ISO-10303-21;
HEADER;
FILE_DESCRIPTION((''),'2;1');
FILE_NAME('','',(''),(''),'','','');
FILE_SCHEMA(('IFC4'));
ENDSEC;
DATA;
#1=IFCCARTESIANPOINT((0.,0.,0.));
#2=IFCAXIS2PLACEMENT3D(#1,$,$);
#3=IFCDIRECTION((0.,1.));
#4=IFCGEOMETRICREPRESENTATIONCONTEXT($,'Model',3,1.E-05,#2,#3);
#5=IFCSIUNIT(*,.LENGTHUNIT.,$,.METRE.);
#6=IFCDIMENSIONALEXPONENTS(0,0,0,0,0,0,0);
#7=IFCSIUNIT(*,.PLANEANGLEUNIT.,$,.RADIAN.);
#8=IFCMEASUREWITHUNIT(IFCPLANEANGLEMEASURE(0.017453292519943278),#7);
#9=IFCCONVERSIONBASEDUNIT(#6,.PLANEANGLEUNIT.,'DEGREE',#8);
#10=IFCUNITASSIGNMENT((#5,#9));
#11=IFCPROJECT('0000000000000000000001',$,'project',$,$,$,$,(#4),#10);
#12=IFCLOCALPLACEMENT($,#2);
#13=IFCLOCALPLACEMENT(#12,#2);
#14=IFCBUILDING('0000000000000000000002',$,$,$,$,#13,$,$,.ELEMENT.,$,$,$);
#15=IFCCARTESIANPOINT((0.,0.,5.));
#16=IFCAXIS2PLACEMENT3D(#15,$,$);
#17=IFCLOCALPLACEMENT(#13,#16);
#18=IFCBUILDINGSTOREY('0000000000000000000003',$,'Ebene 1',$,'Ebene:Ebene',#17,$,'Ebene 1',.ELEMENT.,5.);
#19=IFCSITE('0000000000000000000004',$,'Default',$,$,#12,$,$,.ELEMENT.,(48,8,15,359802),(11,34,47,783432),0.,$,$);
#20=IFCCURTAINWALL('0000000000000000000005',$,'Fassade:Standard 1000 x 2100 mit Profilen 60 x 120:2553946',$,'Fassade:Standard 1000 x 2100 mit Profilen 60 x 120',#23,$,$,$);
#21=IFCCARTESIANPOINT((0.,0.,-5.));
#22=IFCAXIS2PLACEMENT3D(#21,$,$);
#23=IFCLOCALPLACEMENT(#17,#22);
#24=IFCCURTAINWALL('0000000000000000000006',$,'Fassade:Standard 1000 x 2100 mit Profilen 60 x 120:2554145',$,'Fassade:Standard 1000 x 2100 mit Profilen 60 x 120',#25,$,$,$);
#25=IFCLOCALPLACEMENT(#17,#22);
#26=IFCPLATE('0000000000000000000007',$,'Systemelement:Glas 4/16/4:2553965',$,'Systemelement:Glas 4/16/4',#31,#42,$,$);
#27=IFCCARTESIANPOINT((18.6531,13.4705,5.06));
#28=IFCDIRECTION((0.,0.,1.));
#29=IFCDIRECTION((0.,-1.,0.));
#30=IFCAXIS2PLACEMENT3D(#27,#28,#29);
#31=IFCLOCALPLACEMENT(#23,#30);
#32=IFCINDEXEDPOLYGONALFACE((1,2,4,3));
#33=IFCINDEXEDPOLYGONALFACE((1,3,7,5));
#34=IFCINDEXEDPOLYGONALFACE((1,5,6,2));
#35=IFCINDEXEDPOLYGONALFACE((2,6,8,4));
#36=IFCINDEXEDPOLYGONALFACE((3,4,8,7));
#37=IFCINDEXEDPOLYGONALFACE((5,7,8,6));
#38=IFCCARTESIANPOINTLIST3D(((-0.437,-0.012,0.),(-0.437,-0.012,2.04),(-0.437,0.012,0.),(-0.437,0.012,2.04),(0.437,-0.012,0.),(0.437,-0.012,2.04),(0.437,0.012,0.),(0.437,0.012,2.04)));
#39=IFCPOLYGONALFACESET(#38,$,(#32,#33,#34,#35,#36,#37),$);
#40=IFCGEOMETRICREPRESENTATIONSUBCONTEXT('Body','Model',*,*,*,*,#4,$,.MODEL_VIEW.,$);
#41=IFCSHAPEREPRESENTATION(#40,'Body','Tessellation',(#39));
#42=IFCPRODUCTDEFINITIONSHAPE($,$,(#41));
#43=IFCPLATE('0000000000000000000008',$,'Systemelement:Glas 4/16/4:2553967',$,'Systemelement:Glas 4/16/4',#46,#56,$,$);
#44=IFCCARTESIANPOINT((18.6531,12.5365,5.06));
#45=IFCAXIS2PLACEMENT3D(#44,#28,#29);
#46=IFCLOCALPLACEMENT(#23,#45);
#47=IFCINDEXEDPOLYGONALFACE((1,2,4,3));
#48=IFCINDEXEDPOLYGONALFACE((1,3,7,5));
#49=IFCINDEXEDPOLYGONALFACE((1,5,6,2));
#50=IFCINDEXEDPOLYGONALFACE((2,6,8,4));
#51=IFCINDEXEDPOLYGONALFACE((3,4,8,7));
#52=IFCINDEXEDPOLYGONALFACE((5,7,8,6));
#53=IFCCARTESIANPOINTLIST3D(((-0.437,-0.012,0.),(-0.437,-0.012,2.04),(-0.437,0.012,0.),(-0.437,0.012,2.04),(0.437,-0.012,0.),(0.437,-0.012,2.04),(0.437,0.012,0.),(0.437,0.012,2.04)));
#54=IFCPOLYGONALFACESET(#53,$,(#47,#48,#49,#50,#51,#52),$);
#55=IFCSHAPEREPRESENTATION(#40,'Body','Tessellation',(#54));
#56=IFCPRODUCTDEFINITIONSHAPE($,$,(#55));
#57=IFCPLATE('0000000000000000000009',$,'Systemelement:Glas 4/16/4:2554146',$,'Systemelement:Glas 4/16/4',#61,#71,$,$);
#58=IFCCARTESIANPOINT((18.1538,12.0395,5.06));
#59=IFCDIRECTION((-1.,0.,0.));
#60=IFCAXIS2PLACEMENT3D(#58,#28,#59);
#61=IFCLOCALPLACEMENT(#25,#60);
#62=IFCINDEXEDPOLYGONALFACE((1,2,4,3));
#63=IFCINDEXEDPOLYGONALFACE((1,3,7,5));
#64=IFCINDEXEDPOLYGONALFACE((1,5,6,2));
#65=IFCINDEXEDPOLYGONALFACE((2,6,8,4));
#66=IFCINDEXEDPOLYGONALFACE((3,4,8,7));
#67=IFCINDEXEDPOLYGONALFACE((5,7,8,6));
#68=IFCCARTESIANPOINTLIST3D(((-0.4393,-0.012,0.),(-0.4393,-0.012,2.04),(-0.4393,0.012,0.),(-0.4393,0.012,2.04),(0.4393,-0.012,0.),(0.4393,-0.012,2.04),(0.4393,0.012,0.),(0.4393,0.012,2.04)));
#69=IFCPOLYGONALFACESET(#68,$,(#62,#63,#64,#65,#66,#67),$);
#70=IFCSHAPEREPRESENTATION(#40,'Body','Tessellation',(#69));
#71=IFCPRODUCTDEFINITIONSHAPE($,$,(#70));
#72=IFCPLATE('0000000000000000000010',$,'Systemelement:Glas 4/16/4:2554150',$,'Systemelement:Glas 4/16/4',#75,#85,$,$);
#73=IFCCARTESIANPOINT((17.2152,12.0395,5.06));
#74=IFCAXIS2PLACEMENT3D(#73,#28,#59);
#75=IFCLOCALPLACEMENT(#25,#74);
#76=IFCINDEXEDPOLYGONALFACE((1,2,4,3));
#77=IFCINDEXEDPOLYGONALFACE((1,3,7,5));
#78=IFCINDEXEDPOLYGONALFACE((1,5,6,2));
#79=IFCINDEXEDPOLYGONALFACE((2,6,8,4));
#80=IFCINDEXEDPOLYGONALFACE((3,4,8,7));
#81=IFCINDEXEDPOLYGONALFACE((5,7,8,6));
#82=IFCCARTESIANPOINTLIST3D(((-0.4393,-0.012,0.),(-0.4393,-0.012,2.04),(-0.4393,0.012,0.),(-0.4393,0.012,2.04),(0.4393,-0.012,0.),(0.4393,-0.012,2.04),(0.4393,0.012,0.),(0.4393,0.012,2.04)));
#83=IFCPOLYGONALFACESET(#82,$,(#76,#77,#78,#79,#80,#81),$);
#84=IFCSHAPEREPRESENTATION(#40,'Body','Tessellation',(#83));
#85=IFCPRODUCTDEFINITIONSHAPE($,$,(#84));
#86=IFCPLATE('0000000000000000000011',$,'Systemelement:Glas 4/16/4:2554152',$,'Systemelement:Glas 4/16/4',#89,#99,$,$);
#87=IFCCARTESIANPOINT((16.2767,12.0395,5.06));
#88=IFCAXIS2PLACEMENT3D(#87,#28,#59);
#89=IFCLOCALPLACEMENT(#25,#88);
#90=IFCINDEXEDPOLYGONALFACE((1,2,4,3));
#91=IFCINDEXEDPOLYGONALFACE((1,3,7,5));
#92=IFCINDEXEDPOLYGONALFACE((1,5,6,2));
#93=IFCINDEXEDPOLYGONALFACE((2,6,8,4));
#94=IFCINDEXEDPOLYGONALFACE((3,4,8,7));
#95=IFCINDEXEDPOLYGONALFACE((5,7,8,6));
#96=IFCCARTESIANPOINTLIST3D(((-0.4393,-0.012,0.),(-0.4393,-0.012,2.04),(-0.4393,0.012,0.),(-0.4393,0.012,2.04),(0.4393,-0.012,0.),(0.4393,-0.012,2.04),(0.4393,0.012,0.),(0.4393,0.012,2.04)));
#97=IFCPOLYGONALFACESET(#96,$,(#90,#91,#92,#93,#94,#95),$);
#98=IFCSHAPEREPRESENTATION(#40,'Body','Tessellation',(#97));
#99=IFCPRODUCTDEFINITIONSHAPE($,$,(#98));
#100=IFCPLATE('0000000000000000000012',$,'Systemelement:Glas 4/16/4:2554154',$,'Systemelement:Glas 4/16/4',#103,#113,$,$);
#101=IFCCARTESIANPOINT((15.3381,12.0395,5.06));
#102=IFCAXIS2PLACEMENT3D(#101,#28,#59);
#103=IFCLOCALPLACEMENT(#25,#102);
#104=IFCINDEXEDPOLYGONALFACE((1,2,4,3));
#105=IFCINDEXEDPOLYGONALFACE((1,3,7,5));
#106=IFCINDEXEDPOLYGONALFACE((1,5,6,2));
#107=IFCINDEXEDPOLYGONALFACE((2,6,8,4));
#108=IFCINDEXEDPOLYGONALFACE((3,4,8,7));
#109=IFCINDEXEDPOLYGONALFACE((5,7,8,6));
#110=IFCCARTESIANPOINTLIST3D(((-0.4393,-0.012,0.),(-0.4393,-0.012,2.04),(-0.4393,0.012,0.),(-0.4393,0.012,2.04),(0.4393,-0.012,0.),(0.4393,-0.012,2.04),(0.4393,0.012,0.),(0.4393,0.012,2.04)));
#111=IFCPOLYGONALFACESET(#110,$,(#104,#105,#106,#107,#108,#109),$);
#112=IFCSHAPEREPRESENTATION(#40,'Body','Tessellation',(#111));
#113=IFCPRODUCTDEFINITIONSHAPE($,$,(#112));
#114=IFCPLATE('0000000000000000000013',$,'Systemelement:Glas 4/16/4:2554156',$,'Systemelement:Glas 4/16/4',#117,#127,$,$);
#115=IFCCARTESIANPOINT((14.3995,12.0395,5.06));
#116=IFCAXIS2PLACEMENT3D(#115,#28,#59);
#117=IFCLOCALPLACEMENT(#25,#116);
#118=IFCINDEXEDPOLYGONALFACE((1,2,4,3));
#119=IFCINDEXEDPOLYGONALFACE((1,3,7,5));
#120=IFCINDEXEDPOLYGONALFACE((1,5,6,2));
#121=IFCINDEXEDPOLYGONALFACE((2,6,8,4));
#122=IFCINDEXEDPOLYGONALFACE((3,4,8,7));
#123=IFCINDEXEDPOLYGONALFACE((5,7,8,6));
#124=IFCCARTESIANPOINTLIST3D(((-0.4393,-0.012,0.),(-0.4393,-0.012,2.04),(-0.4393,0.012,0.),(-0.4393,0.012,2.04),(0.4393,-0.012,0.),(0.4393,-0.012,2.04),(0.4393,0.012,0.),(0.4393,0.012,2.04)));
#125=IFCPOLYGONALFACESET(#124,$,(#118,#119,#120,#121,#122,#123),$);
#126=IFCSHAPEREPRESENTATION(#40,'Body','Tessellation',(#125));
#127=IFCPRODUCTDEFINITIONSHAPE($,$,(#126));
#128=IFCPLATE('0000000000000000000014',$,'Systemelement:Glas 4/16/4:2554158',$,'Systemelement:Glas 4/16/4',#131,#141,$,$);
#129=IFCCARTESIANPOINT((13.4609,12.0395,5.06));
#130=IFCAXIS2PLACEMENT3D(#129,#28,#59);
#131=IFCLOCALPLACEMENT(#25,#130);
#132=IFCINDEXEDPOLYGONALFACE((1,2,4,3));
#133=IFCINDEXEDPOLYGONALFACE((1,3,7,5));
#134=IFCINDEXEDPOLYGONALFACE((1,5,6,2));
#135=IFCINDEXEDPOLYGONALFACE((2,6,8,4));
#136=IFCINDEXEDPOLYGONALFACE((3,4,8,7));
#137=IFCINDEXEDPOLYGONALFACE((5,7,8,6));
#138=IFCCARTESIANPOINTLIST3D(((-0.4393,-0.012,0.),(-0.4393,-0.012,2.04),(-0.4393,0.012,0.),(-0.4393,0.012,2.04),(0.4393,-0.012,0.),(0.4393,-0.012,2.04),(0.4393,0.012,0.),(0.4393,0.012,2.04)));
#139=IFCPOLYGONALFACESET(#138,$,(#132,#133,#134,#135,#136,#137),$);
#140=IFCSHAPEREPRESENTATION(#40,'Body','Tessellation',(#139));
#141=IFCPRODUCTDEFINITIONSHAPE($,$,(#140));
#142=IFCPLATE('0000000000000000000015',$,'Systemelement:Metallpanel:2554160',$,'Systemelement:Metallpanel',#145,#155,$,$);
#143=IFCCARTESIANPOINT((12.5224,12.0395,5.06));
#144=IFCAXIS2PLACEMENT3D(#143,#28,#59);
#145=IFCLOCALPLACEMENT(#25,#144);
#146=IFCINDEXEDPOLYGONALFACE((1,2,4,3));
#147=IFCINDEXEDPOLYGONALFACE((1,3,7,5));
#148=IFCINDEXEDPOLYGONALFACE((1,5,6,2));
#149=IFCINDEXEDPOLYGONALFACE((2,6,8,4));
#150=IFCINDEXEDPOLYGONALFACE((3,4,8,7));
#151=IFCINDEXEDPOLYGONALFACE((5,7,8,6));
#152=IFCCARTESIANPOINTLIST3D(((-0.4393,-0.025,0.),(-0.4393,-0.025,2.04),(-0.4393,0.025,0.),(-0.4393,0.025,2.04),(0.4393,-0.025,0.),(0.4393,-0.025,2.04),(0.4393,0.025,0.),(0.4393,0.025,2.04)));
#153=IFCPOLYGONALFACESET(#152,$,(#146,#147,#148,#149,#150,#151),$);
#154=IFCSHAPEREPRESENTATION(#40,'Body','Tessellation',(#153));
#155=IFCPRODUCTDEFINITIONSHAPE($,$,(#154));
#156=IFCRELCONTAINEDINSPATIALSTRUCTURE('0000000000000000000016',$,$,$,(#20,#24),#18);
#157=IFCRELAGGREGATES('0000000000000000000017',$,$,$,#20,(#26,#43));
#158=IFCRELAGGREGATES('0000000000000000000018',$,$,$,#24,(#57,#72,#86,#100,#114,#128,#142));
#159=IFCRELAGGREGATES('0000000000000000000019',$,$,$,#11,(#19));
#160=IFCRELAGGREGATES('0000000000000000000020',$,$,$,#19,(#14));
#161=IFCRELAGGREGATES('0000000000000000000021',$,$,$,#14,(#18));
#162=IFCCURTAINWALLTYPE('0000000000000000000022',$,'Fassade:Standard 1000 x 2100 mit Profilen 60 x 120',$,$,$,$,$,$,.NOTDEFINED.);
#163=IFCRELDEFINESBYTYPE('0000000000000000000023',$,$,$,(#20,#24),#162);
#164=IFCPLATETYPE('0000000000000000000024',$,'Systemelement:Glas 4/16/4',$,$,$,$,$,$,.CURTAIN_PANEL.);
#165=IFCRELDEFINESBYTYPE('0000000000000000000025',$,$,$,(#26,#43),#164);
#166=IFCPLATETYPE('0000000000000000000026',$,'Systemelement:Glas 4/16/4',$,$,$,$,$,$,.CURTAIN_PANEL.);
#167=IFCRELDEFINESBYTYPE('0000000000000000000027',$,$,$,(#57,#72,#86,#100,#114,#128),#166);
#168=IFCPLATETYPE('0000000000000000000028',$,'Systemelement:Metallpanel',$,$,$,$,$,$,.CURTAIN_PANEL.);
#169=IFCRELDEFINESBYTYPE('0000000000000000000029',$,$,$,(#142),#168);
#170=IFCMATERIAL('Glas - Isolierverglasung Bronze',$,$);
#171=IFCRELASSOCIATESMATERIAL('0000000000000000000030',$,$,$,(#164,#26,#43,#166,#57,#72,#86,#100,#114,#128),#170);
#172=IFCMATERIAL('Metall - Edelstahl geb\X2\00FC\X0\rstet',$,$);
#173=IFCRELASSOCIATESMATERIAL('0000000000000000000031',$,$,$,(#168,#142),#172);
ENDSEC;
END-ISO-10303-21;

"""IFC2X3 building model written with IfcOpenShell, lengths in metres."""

from ifc_helpers import new_model, entity, si_unit, converted_unit, direction, frame, origin, origin_2d_with_axis, place, context, subcontext, project, spatial, rectangle, extrude, source, transform, mapped, material, type_object, type_shapes, element, aggregate, save


model = new_model("IFC2X3")

# Units and contexts
model_context = context("Model", 3, precision=1e-05, world=origin(), true_north=direction((0.0, 1.0)))
body_context = subcontext(model_context, "Body", "Model", "MODEL_VIEW")
ifc_project = project(units=[si_unit("LENGTHUNIT", "METRE"), converted_unit("PLANEANGLEUNIT", "DEGREE", entity("IfcPlaneAngleMeasure", 0.017453292519943278), si_unit("PLANEANGLEUNIT", "RADIAN"), dimensions=[0, 0, 0, 0, 0, 0, 0])], contexts=[model_context])

# Site, building, storey
site_placement = place(None, origin())
site = spatial("IfcSite", under=ifc_project, at=site_placement, Name="Default", CompositionType="ELEMENT", RefLatitude=(48, 8, 15, 359802), RefLongitude=(11, 34, 47, 783432), RefElevation=0.0)
building_placement = place(site_placement, origin())
building = spatial("IfcBuilding", under=site, at=building_placement, CompositionType="ELEMENT")
storey_placement = place(building_placement, frame((0.0, 0.0, 5.0)))
storey = spatial("IfcBuildingStorey", under=building, at=storey_placement, Name="Ebene 1", ObjectType="Ebene:Ebene", LongName="Ebene 1", CompositionType="ELEMENT", Elevation=5.0)

# Curtain walls
curtain_wall_type = type_object("IfcCurtainWallType", Name="Fassade:Standard 1000 x 2100 mit Profilen 60 x 120", PredefinedType="NOTDEFINED")
curtain_wall_1_placement = place(storey_placement, frame((0.0, 0.0, -5.0)))
curtain_wall_1 = element("IfcCurtainWall", 1, at=curtain_wall_1_placement, inside=storey, type_object=curtain_wall_type, Name="Fassade:Standard 1000 x 2100 mit Profilen 60 x 120:2553946", ObjectType="Fassade:Standard 1000 x 2100 mit Profilen 60 x 120")
curtain_wall_2_placement = place(storey_placement, frame((0.0, 0.0, -5.0)))
curtain_wall_2 = element("IfcCurtainWall", 2, at=curtain_wall_2_placement, inside=storey, type_object=curtain_wall_type, Name="Fassade:Standard 1000 x 2100 mit Profilen 60 x 120:2554145", ObjectType="Fassade:Standard 1000 x 2100 mit Profilen 60 x 120")

# Plates
ifc_material_1 = material(Name="Glas - Isolierverglasung Bronze")
plate_type_1 = type_object("IfcPlateType", Name="Systemelement:Glas 4/16/4", PredefinedType="CURTAIN_PANEL", material=ifc_material_1)
shared_shape_1 = source(origin(), body_context, "Body", "SweptSolid", [
    extrude(rectangle(XDim=0.024, YDim=0.874, at=origin_2d_with_axis()), frame((0.0, 0.0, 0.0), z_axis=(0.0, 0.0, 1.0), x_axis=(0.0, 1.0, 0.0)), (0.0, 0.0, 1.0), 2.04),
])
type_shapes(plate_type_1, [shared_shape_1])
plate_1_placement = place(curtain_wall_1_placement, frame((18.6531, 13.4705, 5.06), z_axis=(0.0, 0.0, 1.0), x_axis=(0.0, -1.0, 0.0)))
plate_1 = element("IfcPlate", 3, at=plate_1_placement, type_object=plate_type_1, material=ifc_material_1, Name="Systemelement:Glas 4/16/4:2553965", ObjectType="Systemelement:Glas 4/16/4", context=body_context, shape_type="MappedRepresentation", body=[
    mapped(shared_shape_1, transform((0.0, 0.0, 0.0), scale=1.0)),
])
plate_2_placement = place(curtain_wall_1_placement, frame((18.6531, 12.5365, 5.06), z_axis=(0.0, 0.0, 1.0), x_axis=(0.0, -1.0, 0.0)))
plate_2 = element("IfcPlate", 4, at=plate_2_placement, type_object=plate_type_1, material=ifc_material_1, Name="Systemelement:Glas 4/16/4:2553967", ObjectType="Systemelement:Glas 4/16/4", context=body_context, shape_type="MappedRepresentation", body=[
    mapped(shared_shape_1, transform((0.0, 0.0, 0.0), scale=1.0)),
])
aggregate(curtain_wall_1, [plate_1, plate_2])
plate_type_2 = type_object("IfcPlateType", Name="Systemelement:Glas 4/16/4", PredefinedType="CURTAIN_PANEL", material=ifc_material_1)
shared_shape_2 = source(origin(), body_context, "Body", "SweptSolid", [
    extrude(rectangle(XDim=0.024, YDim=0.8786, at=origin_2d_with_axis()), frame((0.0, 0.0, 0.0), z_axis=(0.0, 0.0, 1.0), x_axis=(0.0, 1.0, 0.0)), (0.0, 0.0, 1.0), 2.04),
])
type_shapes(plate_type_2, [shared_shape_2])
plate_3_placement = place(curtain_wall_2_placement, frame((18.1538, 12.0395, 5.06), z_axis=(0.0, 0.0, 1.0), x_axis=(-1.0, 0.0, 0.0)))
plate_3 = element("IfcPlate", 5, at=plate_3_placement, type_object=plate_type_2, material=ifc_material_1, Name="Systemelement:Glas 4/16/4:2554146", ObjectType="Systemelement:Glas 4/16/4", context=body_context, shape_type="MappedRepresentation", body=[
    mapped(shared_shape_2, transform((0.0, 0.0, 0.0), scale=1.0)),
])
plate_4_placement = place(curtain_wall_2_placement, frame((17.2152, 12.0395, 5.06), z_axis=(0.0, 0.0, 1.0), x_axis=(-1.0, 0.0, 0.0)))
plate_4 = element("IfcPlate", 6, at=plate_4_placement, type_object=plate_type_2, material=ifc_material_1, Name="Systemelement:Glas 4/16/4:2554150", ObjectType="Systemelement:Glas 4/16/4", context=body_context, shape_type="MappedRepresentation", body=[
    mapped(shared_shape_2, transform((0.0, 0.0, 0.0), scale=1.0)),
])
plate_5_placement = place(curtain_wall_2_placement, frame((16.2767, 12.0395, 5.06), z_axis=(0.0, 0.0, 1.0), x_axis=(-1.0, 0.0, 0.0)))
plate_5 = element("IfcPlate", 7, at=plate_5_placement, type_object=plate_type_2, material=ifc_material_1, Name="Systemelement:Glas 4/16/4:2554152", ObjectType="Systemelement:Glas 4/16/4", context=body_context, shape_type="MappedRepresentation", body=[
    mapped(shared_shape_2, transform((0.0, 0.0, 0.0), scale=1.0)),
])
plate_6_placement = place(curtain_wall_2_placement, frame((15.3381, 12.0395, 5.06), z_axis=(0.0, 0.0, 1.0), x_axis=(-1.0, 0.0, 0.0)))
plate_6 = element("IfcPlate", 8, at=plate_6_placement, type_object=plate_type_2, material=ifc_material_1, Name="Systemelement:Glas 4/16/4:2554154", ObjectType="Systemelement:Glas 4/16/4", context=body_context, shape_type="MappedRepresentation", body=[
    mapped(shared_shape_2, transform((0.0, 0.0, 0.0), scale=1.0)),
])
plate_7_placement = place(curtain_wall_2_placement, frame((14.3995, 12.0395, 5.06), z_axis=(0.0, 0.0, 1.0), x_axis=(-1.0, 0.0, 0.0)))
plate_7 = element("IfcPlate", 9, at=plate_7_placement, type_object=plate_type_2, material=ifc_material_1, Name="Systemelement:Glas 4/16/4:2554156", ObjectType="Systemelement:Glas 4/16/4", context=body_context, shape_type="MappedRepresentation", body=[
    mapped(shared_shape_2, transform((0.0, 0.0, 0.0), scale=1.0)),
])
plate_8_placement = place(curtain_wall_2_placement, frame((13.4609, 12.0395, 5.06), z_axis=(0.0, 0.0, 1.0), x_axis=(-1.0, 0.0, 0.0)))
plate_8 = element("IfcPlate", 10, at=plate_8_placement, type_object=plate_type_2, material=ifc_material_1, Name="Systemelement:Glas 4/16/4:2554158", ObjectType="Systemelement:Glas 4/16/4", context=body_context, shape_type="MappedRepresentation", body=[
    mapped(shared_shape_2, transform((0.0, 0.0, 0.0), scale=1.0)),
])
ifc_material_2 = material(Name="Metall - Edelstahl gebürstet")
plate_type_3 = type_object("IfcPlateType", Name="Systemelement:Metallpanel", PredefinedType="CURTAIN_PANEL", material=ifc_material_2)
shared_shape_3 = source(origin(), body_context, "Body", "SweptSolid", [
    extrude(rectangle(XDim=0.05, YDim=0.8786, at=origin_2d_with_axis()), frame((0.0, 0.0, 0.0), z_axis=(0.0, 0.0, 1.0), x_axis=(0.0, 1.0, 0.0)), (0.0, 0.0, 1.0), 2.04),
])
type_shapes(plate_type_3, [shared_shape_3])
plate_9_placement = place(curtain_wall_2_placement, frame((12.5224, 12.0395, 5.06), z_axis=(0.0, 0.0, 1.0), x_axis=(-1.0, 0.0, 0.0)))
plate_9 = element("IfcPlate", 11, at=plate_9_placement, type_object=plate_type_3, material=ifc_material_2, Name="Systemelement:Metallpanel:2554160", ObjectType="Systemelement:Metallpanel", context=body_context, shape_type="MappedRepresentation", body=[
    mapped(shared_shape_3, transform((0.0, 0.0, 0.0), scale=1.0)),
])
aggregate(curtain_wall_2, [plate_3, plate_4, plate_5, plate_6, plate_7, plate_8, plate_9])

save(model, "model.ifc")
